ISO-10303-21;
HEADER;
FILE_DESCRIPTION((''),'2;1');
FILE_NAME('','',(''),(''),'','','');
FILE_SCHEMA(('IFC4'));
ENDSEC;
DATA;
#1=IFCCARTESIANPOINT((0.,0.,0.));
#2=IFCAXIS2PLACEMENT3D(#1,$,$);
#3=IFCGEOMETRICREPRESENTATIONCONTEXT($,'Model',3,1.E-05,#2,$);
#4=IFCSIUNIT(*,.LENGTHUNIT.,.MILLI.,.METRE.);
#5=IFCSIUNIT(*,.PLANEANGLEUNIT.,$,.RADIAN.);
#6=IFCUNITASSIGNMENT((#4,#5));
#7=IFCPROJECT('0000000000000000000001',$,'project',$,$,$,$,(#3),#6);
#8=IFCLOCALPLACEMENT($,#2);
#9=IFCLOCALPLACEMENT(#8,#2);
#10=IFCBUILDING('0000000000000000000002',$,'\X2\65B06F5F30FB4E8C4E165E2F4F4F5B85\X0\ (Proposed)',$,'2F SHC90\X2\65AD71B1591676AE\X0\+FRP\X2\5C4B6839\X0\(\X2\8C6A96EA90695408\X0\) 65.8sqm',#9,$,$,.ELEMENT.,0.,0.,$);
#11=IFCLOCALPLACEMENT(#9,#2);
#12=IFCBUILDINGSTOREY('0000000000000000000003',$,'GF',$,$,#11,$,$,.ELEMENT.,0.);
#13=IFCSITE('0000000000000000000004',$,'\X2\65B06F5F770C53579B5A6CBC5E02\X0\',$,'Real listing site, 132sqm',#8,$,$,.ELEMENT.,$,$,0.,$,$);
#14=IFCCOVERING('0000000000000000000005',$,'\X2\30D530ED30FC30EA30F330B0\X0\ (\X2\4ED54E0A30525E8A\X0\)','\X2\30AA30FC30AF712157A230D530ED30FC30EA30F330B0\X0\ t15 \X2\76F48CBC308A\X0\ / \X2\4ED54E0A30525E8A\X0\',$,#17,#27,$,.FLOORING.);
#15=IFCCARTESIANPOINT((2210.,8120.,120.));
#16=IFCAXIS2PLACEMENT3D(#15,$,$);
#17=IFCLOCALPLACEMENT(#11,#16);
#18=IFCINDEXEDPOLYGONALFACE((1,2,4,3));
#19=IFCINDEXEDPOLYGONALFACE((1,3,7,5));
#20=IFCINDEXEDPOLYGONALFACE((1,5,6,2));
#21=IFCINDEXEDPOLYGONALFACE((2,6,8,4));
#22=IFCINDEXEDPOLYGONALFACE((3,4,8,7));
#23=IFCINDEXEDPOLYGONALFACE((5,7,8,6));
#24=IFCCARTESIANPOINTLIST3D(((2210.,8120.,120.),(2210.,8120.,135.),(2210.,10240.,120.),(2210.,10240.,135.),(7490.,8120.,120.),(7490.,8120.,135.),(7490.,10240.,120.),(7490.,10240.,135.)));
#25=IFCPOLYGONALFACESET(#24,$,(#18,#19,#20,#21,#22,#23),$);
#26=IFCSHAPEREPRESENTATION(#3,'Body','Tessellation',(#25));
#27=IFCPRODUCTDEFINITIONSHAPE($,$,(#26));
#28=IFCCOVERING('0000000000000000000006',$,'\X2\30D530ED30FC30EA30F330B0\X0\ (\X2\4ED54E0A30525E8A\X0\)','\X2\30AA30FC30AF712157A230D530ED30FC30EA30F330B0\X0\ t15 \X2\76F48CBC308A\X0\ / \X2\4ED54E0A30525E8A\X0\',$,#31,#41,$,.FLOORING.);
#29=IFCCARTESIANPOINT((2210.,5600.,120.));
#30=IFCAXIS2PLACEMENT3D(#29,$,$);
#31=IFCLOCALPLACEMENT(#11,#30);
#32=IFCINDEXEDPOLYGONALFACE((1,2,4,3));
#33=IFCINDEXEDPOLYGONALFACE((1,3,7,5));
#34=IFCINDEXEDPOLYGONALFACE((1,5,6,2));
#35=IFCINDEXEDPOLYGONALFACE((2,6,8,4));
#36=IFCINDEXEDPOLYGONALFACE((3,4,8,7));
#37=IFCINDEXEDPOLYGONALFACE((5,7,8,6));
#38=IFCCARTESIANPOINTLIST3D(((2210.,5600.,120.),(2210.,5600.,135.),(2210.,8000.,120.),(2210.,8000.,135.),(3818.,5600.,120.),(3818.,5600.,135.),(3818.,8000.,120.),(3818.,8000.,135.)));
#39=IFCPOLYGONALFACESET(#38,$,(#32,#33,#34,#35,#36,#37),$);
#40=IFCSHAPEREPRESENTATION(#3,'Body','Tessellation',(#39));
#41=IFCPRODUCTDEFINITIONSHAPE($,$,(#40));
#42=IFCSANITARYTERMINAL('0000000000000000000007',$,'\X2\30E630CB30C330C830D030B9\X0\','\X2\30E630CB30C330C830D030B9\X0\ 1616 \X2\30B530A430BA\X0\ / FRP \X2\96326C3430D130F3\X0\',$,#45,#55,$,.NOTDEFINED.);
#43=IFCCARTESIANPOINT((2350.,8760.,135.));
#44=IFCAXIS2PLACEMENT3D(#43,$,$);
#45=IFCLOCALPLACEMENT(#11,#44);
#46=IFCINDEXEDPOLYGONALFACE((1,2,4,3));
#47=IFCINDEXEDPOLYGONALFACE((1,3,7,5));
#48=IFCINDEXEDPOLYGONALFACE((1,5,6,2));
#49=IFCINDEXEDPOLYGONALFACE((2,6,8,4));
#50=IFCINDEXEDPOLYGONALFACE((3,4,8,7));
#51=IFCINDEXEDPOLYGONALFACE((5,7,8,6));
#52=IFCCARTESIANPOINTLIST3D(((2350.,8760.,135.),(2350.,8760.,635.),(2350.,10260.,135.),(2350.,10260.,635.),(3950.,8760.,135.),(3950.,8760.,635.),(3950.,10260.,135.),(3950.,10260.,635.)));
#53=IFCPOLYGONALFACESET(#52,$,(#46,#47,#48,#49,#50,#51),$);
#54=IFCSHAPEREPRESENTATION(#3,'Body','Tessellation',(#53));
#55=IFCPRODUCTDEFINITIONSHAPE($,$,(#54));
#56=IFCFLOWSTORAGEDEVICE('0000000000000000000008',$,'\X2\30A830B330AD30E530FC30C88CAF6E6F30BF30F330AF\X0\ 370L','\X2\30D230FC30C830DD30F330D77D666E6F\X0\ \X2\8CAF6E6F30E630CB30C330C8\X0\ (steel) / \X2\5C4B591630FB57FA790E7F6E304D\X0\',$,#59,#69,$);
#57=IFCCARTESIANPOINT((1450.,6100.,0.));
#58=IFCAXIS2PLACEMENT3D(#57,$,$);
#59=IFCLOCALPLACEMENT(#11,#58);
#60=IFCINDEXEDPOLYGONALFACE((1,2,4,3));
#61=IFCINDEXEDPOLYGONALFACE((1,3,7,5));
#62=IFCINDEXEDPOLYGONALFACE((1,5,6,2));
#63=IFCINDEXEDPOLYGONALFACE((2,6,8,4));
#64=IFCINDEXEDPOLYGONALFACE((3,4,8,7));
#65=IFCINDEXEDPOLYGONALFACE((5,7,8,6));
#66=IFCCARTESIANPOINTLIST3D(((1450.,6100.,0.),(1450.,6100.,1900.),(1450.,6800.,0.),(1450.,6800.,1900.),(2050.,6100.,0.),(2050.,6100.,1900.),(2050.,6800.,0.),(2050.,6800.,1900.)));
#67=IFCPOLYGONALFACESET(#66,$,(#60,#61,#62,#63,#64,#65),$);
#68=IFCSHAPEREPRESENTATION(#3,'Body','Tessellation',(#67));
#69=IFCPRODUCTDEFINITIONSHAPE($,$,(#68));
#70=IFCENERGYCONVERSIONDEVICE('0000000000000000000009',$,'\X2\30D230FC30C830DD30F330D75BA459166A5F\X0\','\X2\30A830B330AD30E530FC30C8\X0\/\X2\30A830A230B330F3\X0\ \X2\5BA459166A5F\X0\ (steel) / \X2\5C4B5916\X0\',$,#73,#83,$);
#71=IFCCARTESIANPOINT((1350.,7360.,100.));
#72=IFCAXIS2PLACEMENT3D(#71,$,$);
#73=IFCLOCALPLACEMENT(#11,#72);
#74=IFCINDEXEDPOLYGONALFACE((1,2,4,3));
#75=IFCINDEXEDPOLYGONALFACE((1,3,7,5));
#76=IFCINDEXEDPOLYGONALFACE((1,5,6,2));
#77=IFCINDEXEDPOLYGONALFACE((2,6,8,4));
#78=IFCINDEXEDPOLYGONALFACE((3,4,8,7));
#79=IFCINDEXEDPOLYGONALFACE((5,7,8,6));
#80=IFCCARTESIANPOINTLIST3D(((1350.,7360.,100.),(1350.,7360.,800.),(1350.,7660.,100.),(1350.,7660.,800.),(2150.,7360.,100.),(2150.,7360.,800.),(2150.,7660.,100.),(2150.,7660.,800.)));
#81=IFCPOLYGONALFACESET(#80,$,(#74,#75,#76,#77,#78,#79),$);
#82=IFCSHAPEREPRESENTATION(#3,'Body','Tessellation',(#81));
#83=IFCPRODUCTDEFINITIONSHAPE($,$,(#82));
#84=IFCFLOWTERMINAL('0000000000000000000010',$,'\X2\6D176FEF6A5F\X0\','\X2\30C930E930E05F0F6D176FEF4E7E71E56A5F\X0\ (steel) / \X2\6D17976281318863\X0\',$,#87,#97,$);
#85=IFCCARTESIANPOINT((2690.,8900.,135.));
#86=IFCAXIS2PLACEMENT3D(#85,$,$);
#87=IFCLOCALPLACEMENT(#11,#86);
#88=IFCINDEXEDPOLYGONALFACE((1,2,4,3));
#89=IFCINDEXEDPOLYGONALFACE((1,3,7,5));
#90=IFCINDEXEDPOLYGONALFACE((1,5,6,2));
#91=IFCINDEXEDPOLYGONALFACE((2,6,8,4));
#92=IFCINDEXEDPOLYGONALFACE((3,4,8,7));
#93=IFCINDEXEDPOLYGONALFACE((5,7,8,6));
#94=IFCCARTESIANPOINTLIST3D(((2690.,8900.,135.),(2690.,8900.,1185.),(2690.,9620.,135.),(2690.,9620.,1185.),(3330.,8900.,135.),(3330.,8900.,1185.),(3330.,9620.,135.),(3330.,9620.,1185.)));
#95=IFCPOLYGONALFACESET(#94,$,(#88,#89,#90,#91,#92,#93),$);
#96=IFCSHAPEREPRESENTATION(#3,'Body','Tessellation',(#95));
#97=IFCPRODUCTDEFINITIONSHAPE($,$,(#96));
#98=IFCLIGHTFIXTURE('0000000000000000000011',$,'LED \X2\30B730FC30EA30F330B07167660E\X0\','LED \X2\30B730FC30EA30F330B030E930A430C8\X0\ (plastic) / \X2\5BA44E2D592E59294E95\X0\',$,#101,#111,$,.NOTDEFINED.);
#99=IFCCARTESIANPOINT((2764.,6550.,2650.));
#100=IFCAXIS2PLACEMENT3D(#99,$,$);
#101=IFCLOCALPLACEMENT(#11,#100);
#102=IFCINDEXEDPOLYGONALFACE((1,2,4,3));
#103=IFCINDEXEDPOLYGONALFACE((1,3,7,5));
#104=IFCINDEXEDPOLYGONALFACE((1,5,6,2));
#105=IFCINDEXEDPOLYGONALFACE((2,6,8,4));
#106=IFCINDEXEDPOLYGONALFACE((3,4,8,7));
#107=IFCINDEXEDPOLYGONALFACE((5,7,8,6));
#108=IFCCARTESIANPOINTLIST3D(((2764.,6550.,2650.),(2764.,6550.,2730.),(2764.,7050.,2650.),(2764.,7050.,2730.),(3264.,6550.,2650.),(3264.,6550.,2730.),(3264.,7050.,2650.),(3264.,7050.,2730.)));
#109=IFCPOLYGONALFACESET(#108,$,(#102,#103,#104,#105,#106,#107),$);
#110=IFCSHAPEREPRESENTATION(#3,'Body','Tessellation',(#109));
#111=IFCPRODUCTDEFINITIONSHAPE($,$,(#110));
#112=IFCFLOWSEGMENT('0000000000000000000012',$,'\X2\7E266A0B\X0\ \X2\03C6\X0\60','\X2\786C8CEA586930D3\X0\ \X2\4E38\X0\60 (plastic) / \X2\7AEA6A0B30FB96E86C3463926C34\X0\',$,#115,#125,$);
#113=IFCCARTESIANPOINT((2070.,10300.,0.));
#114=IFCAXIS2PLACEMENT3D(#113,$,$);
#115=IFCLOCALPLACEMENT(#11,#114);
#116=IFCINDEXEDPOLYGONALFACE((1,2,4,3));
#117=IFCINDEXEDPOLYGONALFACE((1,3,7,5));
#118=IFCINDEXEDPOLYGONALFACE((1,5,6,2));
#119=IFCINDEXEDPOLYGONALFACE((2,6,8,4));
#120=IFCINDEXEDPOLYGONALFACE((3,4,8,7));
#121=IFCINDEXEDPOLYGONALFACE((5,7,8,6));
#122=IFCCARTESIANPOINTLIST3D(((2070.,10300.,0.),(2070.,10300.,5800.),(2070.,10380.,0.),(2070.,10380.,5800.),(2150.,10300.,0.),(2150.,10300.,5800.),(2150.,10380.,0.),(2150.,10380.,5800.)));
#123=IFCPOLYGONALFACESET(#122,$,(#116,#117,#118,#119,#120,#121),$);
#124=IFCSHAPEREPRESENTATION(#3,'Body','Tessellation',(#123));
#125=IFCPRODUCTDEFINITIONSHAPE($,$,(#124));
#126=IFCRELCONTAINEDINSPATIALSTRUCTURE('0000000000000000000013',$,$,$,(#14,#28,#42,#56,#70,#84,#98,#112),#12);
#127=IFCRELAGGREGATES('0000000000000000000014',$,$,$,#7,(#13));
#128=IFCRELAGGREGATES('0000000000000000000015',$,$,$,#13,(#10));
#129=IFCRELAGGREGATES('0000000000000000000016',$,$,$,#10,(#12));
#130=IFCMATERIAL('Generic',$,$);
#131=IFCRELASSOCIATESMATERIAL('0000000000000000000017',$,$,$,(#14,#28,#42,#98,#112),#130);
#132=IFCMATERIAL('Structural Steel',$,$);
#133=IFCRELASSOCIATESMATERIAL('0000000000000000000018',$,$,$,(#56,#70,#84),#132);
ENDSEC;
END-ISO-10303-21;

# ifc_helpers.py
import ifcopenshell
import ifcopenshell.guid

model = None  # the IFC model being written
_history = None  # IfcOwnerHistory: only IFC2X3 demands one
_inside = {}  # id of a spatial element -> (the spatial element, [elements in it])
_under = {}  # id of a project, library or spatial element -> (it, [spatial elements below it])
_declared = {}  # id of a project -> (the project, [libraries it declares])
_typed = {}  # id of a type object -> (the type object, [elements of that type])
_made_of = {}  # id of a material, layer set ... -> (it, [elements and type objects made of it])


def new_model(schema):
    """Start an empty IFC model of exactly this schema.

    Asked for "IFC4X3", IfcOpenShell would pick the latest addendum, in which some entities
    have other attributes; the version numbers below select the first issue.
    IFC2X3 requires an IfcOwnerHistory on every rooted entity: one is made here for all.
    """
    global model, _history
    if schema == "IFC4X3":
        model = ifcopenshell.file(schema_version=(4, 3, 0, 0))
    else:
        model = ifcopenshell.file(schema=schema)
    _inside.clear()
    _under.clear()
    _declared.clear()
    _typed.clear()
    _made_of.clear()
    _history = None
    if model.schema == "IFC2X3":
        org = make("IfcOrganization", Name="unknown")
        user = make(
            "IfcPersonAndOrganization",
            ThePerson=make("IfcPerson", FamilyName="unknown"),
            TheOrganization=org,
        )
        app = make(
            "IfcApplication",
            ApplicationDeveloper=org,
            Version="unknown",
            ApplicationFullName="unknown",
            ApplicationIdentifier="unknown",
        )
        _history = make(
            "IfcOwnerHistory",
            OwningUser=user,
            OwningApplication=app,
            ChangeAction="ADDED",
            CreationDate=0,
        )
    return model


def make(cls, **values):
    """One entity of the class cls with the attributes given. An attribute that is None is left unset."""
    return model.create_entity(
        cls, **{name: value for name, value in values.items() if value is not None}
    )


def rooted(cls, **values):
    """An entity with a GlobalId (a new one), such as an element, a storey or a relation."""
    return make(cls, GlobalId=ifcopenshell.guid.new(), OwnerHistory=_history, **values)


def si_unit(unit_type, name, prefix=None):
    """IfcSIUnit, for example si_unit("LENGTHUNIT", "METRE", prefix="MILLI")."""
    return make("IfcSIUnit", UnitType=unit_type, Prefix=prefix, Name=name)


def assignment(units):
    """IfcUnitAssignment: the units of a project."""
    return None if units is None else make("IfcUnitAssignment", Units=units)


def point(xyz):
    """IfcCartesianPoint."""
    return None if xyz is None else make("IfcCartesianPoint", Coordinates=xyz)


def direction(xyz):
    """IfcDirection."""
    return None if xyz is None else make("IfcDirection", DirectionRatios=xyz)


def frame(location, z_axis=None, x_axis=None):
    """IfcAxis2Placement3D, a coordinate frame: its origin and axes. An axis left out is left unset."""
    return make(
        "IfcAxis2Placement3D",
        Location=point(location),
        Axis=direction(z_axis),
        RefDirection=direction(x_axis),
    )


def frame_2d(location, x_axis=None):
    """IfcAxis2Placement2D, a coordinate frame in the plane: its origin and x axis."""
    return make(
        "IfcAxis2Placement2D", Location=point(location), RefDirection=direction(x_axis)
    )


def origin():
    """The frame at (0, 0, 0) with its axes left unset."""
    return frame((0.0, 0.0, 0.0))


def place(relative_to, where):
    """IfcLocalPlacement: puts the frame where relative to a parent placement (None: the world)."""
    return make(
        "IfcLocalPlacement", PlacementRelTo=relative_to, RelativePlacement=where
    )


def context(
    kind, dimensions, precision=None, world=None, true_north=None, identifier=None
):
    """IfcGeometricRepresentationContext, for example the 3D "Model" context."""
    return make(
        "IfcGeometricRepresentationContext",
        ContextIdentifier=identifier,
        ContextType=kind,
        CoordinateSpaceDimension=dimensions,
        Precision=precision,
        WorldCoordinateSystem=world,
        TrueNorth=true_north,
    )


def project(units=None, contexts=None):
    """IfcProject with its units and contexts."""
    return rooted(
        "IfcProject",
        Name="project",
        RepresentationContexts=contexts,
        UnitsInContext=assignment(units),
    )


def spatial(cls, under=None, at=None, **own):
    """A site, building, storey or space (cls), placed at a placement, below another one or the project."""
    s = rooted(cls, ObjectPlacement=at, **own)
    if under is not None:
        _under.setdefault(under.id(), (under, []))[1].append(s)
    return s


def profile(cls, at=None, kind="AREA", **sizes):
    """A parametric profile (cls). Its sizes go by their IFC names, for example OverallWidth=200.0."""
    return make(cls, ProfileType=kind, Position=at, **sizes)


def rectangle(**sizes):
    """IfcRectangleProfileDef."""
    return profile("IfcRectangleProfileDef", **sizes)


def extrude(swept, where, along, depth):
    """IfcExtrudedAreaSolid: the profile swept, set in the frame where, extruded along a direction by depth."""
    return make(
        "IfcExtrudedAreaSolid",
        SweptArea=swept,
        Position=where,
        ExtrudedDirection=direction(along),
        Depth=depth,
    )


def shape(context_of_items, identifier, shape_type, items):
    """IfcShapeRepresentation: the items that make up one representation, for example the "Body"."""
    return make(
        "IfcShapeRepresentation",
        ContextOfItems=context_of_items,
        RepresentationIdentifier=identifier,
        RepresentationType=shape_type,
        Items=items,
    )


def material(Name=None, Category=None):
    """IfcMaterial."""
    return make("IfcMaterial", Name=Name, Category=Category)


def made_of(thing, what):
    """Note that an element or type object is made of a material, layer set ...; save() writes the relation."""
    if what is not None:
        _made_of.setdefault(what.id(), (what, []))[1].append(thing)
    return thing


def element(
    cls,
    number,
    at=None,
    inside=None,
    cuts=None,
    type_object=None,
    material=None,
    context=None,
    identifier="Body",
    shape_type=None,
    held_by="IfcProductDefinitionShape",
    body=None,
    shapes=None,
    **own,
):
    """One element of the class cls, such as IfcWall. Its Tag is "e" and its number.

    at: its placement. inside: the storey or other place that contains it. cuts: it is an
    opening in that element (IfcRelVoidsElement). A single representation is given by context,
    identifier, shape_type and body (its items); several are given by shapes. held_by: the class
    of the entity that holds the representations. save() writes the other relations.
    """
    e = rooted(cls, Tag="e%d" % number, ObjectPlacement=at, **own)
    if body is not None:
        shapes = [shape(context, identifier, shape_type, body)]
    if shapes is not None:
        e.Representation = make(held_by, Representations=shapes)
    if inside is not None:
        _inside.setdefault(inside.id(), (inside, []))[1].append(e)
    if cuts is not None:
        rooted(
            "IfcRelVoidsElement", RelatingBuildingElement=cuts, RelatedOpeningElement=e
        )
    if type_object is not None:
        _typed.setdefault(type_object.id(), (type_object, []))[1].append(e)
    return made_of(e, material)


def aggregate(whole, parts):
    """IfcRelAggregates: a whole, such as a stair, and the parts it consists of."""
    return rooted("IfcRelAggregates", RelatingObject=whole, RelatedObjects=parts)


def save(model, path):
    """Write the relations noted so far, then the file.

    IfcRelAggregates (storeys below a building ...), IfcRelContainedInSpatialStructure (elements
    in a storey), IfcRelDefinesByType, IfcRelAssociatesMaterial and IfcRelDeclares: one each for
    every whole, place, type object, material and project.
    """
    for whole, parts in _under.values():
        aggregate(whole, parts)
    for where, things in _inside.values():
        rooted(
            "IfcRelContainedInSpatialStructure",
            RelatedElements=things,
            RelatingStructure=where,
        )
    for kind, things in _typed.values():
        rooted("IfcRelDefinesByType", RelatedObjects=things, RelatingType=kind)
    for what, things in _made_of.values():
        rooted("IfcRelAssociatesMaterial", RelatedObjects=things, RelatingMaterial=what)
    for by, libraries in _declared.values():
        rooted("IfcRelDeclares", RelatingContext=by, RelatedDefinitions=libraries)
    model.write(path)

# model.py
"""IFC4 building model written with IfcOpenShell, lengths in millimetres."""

from ifc_helpers import new_model, si_unit, frame, frame_2d, origin, place, context, project, spatial, rectangle, extrude, material, element, save


model = new_model("IFC4")

# Units and contexts
model_context = context("Model", 3, precision=1e-05, world=origin())
ifc_project = project(units=[si_unit("LENGTHUNIT", "METRE", prefix="MILLI"), si_unit("PLANEANGLEUNIT", "RADIAN")], contexts=[model_context])

# Site, building, storey
site_placement = place(None, origin())
site = spatial("IfcSite", under=ifc_project, at=site_placement, Name="新潟県南魚沼市", ObjectType="Real listing site, 132sqm", CompositionType="ELEMENT", RefElevation=0.0)
building_placement = place(site_placement, origin())
building = spatial("IfcBuilding", under=site, at=building_placement, Name="新潟・二世帯住宅 (Proposed)", ObjectType="2F SHC90断熱外皮+FRP屋根(豪雪適合) 65.8sqm", CompositionType="ELEMENT", ElevationOfRefHeight=0.0, ElevationOfTerrain=0.0)
storey_placement = place(building_placement, origin())
storey = spatial("IfcBuildingStorey", under=building, at=storey_placement, Name="GF", CompositionType="ELEMENT", Elevation=0.0)

# Coverings
ifc_material_1 = material(Name="Generic")
covering_1_placement = place(storey_placement, frame((2210.0, 8120.0, 120.0)))
element("IfcCovering", 1, at=covering_1_placement, inside=storey, material=ifc_material_1, Name="フローリング (仕上げ床)", Description="オーク無垢フローリング t15 直貼り / 仕上げ床", PredefinedType="FLOORING", context=model_context, shape_type="SweptSolid", body=[
    extrude(rectangle(XDim=5280.0, YDim=2120.0, at=frame_2d((2640.0, 1060.0))), frame((2210.0, 8120.0, 120.0)), (0.0, 0.0, 1.0), 15.0),
])
covering_2_placement = place(storey_placement, frame((2210.0, 5600.0, 120.0)))
element("IfcCovering", 2, at=covering_2_placement, inside=storey, material=ifc_material_1, Name="フローリング (仕上げ床)", Description="オーク無垢フローリング t15 直貼り / 仕上げ床", PredefinedType="FLOORING", context=model_context, shape_type="SweptSolid", body=[
    extrude(rectangle(XDim=1608.0, YDim=2400.0, at=frame_2d((804.0, 1200.0))), frame((2210.0, 5600.0, 120.0)), (0.0, 0.0, 1.0), 15.0),
])

# Sanitary terminal
sanitary_terminal_placement = place(storey_placement, frame((2350.0, 8760.0, 135.0)))
element("IfcSanitaryTerminal", 3, at=sanitary_terminal_placement, inside=storey, material=ifc_material_1, Name="ユニットバス", Description="ユニットバス 1616 サイズ / FRP 防水パン", PredefinedType="NOTDEFINED", context=model_context, shape_type="SweptSolid", body=[
    extrude(rectangle(XDim=1600.0, YDim=1500.0, at=frame_2d((800.0, 750.0))), frame((2350.0, 8760.0, 135.0)), (0.0, 0.0, 1.0), 500.0),
])

# Flow storage device
ifc_material_2 = material(Name="Structural Steel")
flow_storage_device_placement = place(storey_placement, frame((1450.0, 6100.0, 0.0)))
element("IfcFlowStorageDevice", 4, at=flow_storage_device_placement, inside=storey, material=ifc_material_2, Name="エコキュート貯湯タンク 370L", Description="ヒートポンプ給湯 貯湯ユニット (steel) / 屋外・基礎置き", context=model_context, shape_type="SweptSolid", body=[
    extrude(rectangle(XDim=600.0, YDim=700.0, at=frame_2d((300.0, 350.0))), frame((1450.0, 6100.0, 0.0)), (0.0, 0.0, 1.0), 1900.0),
])

# Energy conversion device
energy_conversion_device_placement = place(storey_placement, frame((1350.0, 7360.0, 100.0)))
element("IfcEnergyConversionDevice", 5, at=energy_conversion_device_placement, inside=storey, material=ifc_material_2, Name="ヒートポンプ室外機", Description="エコキュート/エアコン 室外機 (steel) / 屋外", context=model_context, shape_type="SweptSolid", body=[
    extrude(rectangle(XDim=800.0, YDim=300.0, at=frame_2d((400.0, 150.0))), frame((1350.0, 7360.0, 100.0)), (0.0, 0.0, 1.0), 700.0),
])

# Flow terminal
flow_terminal_placement = place(storey_placement, frame((2690.0, 8900.0, 135.0)))
element("IfcFlowTerminal", 6, at=flow_terminal_placement, inside=storey, material=ifc_material_2, Name="洗濯機", Description="ドラム式洗濯乾燥機 (steel) / 洗面脱衣", context=model_context, shape_type="SweptSolid", body=[
    extrude(rectangle(XDim=640.0, YDim=720.0, at=frame_2d((320.0, 360.0))), frame((2690.0, 8900.0, 135.0)), (0.0, 0.0, 1.0), 1050.0),
])

# Light fixture
light_fixture_placement = place(storey_placement, frame((2764.0, 6550.0, 2650.0)))
element("IfcLightFixture", 7, at=light_fixture_placement, inside=storey, material=ifc_material_1, Name="LED シーリング照明", Description="LED シーリングライト (plastic) / 室中央天井", PredefinedType="NOTDEFINED", context=model_context, shape_type="SweptSolid", body=[
    extrude(rectangle(XDim=500.0, YDim=500.0, at=frame_2d((250.0, 250.0))), frame((2764.0, 6550.0, 2650.0)), (0.0, 0.0, 1.0), 80.0),
])

# Flow segment
flow_segment_placement = place(storey_placement, frame((2070.0, 10300.0, 0.0)))
element("IfcFlowSegment", 8, at=flow_segment_placement, inside=storey, material=ifc_material_1, Name="縦樋 φ60", Description="硬質塩ビ 丸60 (plastic) / 竪樋・雨水排水", context=model_context, shape_type="SweptSolid", body=[
    extrude(rectangle(XDim=80.0, YDim=80.0, at=frame_2d((40.0, 40.0))), frame((2070.0, 10300.0, 0.0)), (0.0, 0.0, 1.0), 5800.0),
])

save(model, "model.ifc")
